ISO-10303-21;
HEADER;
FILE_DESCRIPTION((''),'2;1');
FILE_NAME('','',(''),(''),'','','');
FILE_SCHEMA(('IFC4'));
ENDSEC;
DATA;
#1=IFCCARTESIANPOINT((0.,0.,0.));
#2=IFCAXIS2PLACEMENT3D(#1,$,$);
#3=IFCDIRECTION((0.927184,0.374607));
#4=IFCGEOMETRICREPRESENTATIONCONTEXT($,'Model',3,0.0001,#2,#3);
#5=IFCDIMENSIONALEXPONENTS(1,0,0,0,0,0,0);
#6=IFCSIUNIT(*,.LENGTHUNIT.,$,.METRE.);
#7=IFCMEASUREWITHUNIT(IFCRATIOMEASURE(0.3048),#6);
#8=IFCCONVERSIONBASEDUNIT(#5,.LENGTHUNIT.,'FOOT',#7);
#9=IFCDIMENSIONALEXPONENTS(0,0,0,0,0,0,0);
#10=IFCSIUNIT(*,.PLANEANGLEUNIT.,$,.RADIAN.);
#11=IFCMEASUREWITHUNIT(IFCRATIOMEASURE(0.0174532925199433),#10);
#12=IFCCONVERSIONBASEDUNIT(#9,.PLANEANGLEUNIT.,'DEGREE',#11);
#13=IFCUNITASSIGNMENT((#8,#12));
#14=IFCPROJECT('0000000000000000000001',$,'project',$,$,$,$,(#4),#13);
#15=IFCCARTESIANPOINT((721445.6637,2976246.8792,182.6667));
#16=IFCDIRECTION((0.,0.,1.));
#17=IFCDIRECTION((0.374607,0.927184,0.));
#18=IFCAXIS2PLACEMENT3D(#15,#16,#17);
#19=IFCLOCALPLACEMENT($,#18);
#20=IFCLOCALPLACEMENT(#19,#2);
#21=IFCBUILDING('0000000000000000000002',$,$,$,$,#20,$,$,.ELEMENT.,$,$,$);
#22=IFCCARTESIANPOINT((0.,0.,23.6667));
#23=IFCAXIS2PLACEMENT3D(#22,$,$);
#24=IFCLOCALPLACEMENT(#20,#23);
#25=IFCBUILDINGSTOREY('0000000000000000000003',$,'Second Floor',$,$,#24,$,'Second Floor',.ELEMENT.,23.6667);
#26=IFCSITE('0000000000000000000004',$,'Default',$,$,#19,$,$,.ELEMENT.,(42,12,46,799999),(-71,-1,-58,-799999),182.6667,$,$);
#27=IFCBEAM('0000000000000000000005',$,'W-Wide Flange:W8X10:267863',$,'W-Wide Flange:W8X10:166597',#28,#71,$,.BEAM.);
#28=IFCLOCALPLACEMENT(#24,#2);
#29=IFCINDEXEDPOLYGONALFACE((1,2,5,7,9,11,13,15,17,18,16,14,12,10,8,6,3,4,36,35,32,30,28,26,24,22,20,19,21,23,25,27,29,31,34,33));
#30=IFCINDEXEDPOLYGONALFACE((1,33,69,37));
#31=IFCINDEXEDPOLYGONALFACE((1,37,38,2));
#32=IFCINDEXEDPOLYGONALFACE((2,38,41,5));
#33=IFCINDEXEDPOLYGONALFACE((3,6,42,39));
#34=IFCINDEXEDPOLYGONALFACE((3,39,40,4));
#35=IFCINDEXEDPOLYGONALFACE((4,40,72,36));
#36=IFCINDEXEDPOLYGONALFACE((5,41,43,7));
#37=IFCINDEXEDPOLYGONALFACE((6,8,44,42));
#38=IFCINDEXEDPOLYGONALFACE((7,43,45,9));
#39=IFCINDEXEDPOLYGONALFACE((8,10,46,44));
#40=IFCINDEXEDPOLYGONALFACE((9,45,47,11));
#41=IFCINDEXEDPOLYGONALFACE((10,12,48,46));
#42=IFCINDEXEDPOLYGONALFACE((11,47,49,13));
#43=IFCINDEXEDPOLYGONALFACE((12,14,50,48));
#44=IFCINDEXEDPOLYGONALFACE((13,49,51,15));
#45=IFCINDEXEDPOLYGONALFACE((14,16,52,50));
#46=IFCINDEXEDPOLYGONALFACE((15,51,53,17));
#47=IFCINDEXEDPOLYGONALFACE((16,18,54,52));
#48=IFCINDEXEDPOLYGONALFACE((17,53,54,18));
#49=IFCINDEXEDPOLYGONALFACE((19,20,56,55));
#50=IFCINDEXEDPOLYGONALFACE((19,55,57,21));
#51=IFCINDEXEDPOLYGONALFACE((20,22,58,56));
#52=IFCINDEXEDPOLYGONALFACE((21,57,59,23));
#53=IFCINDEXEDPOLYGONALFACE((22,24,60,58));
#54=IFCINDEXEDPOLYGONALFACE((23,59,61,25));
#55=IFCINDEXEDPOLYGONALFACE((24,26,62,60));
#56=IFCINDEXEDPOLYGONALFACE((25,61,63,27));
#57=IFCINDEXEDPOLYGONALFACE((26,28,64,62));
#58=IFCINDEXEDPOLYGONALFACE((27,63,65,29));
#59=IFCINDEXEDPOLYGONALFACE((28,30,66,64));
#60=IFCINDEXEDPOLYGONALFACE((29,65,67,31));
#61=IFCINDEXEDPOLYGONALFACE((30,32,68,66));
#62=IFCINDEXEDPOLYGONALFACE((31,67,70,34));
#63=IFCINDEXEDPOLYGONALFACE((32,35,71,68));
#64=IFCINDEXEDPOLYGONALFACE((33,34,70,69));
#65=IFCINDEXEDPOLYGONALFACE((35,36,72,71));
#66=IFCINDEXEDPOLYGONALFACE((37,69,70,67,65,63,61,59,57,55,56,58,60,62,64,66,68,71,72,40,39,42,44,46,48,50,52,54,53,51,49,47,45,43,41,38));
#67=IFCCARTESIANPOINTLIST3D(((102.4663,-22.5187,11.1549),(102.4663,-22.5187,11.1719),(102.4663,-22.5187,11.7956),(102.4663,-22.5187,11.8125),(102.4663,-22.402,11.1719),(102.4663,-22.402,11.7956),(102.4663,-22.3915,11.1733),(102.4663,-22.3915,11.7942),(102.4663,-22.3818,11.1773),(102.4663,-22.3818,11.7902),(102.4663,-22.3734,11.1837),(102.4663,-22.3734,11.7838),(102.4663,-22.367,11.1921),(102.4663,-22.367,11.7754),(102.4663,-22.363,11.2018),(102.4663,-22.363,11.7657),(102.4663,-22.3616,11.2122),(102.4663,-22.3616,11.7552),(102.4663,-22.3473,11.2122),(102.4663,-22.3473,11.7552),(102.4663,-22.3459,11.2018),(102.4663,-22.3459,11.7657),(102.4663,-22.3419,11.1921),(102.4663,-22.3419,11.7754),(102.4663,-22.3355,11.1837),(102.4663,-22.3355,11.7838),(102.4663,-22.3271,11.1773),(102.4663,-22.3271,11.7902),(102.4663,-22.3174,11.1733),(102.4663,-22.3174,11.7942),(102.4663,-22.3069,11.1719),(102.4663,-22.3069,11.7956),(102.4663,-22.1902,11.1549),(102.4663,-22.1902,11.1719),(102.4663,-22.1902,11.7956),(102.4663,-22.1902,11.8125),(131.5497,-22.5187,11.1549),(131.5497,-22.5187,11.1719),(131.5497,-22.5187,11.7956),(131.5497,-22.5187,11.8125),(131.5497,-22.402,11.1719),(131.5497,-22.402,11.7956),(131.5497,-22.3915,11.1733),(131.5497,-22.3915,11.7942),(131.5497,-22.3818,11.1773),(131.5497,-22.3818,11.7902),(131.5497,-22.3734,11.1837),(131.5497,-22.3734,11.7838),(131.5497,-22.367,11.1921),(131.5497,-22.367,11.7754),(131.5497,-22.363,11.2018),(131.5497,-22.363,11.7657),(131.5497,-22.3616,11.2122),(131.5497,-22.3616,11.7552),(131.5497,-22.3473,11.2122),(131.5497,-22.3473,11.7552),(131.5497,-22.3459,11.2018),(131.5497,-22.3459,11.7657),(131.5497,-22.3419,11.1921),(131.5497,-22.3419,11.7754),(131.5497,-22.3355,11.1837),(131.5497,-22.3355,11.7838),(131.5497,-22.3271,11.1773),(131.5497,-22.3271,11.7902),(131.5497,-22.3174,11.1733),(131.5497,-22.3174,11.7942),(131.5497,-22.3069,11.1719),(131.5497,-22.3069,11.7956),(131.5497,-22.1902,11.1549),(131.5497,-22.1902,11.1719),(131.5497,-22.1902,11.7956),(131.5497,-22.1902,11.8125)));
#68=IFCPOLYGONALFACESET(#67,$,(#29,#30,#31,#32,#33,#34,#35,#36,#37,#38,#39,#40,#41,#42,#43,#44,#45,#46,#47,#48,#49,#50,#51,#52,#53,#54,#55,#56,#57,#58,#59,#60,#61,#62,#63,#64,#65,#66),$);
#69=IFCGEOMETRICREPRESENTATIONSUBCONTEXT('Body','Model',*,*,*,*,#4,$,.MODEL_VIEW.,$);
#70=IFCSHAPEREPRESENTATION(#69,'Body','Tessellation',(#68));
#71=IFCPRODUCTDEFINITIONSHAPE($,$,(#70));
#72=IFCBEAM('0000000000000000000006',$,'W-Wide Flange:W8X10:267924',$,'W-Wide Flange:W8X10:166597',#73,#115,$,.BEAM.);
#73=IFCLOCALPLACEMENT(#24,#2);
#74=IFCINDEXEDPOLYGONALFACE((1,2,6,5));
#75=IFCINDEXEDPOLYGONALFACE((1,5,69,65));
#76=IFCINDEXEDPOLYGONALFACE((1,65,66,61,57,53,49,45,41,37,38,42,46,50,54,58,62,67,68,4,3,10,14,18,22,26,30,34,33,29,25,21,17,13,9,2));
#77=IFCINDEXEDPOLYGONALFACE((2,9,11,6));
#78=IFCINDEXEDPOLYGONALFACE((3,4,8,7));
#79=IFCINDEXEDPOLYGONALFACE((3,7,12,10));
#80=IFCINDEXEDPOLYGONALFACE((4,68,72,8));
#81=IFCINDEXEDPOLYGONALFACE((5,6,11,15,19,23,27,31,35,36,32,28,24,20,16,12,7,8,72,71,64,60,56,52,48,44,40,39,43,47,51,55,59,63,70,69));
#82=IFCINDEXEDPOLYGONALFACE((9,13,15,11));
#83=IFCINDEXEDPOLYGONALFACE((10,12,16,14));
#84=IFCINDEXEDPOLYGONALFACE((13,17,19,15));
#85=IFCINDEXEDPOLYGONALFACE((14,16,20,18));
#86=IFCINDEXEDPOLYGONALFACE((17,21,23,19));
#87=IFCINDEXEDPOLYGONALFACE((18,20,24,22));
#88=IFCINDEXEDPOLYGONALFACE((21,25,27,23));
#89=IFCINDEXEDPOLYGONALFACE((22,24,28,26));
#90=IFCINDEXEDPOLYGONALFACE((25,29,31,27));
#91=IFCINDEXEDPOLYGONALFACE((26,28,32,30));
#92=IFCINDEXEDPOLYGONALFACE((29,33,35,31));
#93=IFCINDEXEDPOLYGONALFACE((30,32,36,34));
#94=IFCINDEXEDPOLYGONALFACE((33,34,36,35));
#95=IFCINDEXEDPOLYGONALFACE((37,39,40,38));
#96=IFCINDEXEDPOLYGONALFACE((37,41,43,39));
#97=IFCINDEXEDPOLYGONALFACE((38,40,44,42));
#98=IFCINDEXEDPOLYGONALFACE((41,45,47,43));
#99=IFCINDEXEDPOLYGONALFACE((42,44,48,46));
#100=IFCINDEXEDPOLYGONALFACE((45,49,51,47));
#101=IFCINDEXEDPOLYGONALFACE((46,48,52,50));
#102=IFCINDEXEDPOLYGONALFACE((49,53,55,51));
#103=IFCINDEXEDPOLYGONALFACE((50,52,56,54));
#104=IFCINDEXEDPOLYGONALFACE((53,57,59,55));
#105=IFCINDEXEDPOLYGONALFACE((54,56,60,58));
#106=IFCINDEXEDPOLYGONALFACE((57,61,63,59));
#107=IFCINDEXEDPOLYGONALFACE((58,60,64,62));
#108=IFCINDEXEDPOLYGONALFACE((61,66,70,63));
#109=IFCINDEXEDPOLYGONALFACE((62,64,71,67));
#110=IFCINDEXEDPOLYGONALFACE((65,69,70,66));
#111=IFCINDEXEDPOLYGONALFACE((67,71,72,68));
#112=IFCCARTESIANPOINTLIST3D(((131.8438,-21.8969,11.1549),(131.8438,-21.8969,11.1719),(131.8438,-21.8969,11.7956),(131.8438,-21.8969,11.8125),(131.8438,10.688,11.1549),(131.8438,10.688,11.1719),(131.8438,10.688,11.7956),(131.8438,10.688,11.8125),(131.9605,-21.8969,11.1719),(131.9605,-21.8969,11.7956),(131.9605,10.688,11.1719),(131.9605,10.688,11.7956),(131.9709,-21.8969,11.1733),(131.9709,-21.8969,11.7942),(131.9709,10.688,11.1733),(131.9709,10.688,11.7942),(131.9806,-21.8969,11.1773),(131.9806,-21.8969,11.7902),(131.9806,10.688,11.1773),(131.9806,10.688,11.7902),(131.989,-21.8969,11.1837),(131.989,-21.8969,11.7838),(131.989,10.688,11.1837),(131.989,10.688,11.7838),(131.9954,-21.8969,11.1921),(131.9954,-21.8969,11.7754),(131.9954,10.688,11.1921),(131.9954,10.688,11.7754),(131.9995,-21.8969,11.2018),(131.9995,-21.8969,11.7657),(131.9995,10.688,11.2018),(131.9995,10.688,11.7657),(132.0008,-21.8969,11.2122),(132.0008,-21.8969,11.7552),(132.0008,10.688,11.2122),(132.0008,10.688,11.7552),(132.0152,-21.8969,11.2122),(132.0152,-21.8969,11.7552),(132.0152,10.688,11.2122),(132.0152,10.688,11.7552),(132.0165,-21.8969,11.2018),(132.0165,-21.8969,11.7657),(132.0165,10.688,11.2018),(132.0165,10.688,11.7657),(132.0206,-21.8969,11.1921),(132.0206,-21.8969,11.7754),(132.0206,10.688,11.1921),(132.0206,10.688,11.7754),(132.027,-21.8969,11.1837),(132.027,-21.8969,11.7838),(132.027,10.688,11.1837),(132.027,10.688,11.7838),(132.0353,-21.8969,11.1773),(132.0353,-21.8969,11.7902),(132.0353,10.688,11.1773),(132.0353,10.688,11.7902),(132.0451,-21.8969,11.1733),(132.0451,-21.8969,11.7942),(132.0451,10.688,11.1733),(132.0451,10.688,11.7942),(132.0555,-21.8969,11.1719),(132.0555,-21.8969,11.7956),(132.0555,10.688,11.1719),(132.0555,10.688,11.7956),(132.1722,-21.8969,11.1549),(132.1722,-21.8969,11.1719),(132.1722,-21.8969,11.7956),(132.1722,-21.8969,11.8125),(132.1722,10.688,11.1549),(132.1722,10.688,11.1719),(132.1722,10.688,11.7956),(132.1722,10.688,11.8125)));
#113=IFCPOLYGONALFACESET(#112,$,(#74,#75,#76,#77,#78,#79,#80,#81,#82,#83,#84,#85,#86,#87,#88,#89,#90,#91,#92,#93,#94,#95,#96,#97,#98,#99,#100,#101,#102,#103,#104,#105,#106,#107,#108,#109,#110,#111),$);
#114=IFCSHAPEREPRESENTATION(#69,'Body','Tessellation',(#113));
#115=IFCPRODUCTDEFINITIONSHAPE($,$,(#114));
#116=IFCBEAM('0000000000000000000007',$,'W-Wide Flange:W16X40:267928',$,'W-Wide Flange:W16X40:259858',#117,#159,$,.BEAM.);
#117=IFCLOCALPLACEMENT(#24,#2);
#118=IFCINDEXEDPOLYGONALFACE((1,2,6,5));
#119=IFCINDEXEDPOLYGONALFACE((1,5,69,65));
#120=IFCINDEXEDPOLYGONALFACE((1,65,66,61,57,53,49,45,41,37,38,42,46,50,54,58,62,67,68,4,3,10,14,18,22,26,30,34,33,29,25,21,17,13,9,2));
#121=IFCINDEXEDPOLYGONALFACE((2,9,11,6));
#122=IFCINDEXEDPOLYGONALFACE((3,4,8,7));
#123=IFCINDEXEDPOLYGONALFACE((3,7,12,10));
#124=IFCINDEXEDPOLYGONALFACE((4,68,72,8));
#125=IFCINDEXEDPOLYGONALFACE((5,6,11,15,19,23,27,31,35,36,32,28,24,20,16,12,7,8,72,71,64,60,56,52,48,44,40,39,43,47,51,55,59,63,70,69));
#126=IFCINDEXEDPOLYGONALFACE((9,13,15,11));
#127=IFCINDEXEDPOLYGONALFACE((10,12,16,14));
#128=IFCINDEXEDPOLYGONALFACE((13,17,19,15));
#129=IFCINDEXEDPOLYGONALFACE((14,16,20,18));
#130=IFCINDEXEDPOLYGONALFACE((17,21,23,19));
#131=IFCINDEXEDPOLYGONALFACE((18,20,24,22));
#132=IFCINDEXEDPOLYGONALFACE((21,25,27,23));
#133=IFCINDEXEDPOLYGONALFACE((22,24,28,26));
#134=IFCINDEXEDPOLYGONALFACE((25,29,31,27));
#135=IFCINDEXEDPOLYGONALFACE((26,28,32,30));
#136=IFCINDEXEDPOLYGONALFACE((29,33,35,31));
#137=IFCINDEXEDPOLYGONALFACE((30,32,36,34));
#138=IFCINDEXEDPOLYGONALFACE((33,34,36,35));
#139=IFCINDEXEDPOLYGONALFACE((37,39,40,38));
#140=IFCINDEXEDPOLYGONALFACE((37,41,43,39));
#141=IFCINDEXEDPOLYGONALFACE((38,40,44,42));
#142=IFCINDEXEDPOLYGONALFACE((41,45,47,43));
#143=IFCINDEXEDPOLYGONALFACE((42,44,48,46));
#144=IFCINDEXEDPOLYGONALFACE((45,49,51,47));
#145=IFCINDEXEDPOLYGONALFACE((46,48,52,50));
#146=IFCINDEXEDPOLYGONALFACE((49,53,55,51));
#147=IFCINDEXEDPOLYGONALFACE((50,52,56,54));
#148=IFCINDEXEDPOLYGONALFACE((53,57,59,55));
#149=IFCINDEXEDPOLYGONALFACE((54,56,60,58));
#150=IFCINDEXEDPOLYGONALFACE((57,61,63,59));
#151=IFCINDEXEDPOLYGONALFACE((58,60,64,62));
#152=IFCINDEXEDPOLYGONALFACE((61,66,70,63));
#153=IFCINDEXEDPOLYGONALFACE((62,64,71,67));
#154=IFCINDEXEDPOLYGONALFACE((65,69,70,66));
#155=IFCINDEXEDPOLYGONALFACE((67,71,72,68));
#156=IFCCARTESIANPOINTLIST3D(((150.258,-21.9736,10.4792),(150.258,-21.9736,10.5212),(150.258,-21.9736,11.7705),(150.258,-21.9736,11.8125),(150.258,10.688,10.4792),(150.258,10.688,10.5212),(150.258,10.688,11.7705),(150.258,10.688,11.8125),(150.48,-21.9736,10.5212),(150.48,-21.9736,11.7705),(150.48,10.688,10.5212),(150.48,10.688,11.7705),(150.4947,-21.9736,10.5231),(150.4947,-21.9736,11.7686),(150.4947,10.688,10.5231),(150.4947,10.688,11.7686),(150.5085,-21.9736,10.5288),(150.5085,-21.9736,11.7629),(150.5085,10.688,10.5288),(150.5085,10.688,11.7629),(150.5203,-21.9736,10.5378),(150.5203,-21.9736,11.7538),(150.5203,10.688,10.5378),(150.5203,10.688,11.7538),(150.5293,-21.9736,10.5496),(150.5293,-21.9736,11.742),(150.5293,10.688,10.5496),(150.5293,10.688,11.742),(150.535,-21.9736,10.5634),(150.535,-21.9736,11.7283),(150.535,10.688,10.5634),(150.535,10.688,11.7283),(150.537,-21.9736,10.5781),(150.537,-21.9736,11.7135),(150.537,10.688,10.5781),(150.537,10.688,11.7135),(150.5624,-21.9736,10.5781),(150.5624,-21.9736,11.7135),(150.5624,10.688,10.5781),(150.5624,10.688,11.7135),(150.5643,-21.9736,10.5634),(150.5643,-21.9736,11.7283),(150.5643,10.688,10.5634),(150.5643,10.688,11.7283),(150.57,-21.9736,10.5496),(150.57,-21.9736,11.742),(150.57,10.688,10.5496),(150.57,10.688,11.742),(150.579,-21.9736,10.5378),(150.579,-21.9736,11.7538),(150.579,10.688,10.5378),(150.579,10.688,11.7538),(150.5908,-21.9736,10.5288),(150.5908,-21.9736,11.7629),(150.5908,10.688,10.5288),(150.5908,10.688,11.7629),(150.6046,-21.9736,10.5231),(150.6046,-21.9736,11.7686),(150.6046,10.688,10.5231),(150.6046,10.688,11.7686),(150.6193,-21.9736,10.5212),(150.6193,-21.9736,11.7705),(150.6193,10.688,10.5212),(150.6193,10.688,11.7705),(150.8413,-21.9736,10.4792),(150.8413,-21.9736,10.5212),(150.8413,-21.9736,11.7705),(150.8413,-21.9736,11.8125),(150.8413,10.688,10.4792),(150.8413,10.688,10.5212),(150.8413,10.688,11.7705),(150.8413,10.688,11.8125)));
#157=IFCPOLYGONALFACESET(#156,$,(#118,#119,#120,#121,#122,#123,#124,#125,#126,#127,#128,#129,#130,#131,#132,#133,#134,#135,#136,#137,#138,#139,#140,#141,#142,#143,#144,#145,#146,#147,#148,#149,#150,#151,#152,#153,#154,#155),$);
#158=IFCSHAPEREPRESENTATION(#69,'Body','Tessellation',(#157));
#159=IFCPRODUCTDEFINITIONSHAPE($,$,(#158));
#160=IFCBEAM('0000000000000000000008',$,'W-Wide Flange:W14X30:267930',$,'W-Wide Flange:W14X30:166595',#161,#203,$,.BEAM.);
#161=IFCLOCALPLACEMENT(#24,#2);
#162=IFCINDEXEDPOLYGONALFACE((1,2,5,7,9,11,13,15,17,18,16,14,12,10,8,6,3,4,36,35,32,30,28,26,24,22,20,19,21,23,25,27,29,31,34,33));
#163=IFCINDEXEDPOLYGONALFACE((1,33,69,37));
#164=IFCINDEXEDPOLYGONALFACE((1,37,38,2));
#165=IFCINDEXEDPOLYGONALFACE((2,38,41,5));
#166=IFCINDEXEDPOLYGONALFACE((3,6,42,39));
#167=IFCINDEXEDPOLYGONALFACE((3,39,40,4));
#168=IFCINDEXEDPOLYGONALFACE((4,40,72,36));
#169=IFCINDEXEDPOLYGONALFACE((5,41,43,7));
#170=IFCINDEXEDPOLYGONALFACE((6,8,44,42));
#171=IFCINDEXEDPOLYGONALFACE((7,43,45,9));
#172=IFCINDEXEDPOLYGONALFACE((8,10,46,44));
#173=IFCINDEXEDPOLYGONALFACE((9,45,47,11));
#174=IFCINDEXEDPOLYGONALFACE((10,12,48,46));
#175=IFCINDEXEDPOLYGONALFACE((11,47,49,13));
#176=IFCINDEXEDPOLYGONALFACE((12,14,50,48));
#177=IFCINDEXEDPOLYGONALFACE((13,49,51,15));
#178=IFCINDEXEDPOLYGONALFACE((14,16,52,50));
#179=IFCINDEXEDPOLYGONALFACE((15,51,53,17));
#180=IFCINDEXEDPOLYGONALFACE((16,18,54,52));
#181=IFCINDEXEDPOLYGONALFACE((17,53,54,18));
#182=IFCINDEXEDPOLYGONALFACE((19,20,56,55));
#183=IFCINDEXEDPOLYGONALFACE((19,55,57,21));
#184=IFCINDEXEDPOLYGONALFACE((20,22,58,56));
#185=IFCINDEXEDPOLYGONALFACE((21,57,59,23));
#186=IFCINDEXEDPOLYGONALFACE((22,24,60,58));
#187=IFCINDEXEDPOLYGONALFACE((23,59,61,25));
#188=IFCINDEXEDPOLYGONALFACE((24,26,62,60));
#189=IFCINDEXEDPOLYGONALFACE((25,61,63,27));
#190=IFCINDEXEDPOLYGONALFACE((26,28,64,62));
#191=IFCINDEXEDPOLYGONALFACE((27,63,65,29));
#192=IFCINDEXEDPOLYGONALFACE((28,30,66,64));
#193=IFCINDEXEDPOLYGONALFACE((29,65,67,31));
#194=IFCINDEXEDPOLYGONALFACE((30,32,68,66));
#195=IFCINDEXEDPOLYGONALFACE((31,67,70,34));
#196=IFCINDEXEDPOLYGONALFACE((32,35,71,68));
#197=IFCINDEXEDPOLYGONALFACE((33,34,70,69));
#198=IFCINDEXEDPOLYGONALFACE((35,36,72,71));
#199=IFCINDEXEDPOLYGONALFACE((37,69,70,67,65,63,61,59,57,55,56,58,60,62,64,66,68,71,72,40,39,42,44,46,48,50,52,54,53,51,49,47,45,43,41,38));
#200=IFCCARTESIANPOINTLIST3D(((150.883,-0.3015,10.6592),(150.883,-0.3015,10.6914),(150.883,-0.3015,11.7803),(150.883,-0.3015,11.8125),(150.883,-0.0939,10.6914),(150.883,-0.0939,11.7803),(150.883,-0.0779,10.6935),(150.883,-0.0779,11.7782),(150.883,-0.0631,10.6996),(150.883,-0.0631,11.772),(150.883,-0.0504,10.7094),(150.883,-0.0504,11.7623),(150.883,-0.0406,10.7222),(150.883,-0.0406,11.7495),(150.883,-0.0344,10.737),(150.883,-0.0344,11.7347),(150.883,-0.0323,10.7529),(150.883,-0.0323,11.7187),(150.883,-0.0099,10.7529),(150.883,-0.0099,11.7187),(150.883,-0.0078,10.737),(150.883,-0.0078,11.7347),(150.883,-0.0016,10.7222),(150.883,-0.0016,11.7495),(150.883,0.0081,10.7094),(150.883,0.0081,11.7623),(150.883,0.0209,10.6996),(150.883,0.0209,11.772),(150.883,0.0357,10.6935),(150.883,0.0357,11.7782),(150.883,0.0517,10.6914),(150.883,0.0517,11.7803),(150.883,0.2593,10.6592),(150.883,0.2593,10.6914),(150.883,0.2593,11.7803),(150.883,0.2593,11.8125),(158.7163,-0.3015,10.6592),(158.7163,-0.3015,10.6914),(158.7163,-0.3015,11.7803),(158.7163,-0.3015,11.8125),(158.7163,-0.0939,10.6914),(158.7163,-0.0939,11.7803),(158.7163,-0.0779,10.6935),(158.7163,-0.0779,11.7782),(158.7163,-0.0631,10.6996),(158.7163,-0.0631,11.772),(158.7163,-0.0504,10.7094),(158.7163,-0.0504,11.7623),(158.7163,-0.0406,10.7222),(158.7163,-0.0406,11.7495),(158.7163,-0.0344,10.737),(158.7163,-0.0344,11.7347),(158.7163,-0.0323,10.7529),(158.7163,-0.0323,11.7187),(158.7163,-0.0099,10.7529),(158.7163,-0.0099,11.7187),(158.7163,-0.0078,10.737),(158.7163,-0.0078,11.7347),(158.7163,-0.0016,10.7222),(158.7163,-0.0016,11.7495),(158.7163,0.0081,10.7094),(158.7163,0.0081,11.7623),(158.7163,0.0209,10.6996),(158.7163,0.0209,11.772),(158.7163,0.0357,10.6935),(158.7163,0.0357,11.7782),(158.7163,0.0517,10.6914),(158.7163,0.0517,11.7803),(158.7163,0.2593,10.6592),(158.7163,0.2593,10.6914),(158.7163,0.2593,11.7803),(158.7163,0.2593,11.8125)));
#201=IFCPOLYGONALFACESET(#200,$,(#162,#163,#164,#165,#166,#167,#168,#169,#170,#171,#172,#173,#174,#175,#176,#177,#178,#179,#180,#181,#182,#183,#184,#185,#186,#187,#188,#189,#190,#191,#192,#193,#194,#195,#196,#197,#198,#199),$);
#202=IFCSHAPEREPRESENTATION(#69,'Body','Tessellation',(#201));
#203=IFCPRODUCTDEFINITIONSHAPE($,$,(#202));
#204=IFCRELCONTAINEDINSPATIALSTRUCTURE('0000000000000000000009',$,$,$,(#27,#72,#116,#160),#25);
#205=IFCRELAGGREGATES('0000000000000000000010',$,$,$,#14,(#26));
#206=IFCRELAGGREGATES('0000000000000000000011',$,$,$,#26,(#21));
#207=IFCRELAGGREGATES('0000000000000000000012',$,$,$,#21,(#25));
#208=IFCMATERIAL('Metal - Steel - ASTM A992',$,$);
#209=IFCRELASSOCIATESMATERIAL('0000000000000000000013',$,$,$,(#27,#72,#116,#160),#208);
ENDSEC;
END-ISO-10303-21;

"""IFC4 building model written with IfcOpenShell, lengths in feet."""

from ifc_helpers import new_model, entity, si_unit, converted_unit, direction, frame, frame_2d, origin, place, context, subcontext, project, spatial, i_section, extrude, material, element, save


model = new_model("IFC4")

# Units and contexts
model_context = context("Model", 3, precision=0.0001, world=origin(), true_north=direction((0.927184, 0.374607)))
body_context = subcontext(model_context, "Body", "Model", "MODEL_VIEW")
ifc_project = project(units=[converted_unit("LENGTHUNIT", "FOOT", entity("IfcRatioMeasure", 0.3048), si_unit("LENGTHUNIT", "METRE"), dimensions=[1, 0, 0, 0, 0, 0, 0]), converted_unit("PLANEANGLEUNIT", "DEGREE", entity("IfcRatioMeasure", 0.0174532925199433), si_unit("PLANEANGLEUNIT", "RADIAN"), dimensions=[0, 0, 0, 0, 0, 0, 0])], contexts=[model_context])

# Site, building, storey
site_placement = place(None, frame((721445.6637, 2976246.8792, 182.6667), z_axis=(0.0, 0.0, 1.0), x_axis=(0.374607, 0.927184, 0.0)))
site = spatial("IfcSite", under=ifc_project, at=site_placement, Name="Default", CompositionType="ELEMENT", RefLatitude=(42, 12, 46, 799999), RefLongitude=(-71, -1, -58, -799999), RefElevation=182.6667)
building_placement = place(site_placement, origin())
building = spatial("IfcBuilding", under=site, at=building_placement, CompositionType="ELEMENT")
storey_placement = place(building_placement, frame((0.0, 0.0, 23.6667)))
storey = spatial("IfcBuildingStorey", under=building, at=storey_placement, Name="Second Floor", LongName="Second Floor", CompositionType="ELEMENT", Elevation=23.6667)

# Shared definitions
ifc_material_1 = material(Name="Metal - Steel - ASTM A992")

# Beams
beam_1_placement = place(storey_placement, frame((102.008, -22.3544, 11.8125)))
element("IfcBeam", 1, at=beam_1_placement, inside=storey, material=ifc_material_1, Name="W-Wide Flange:W8X10:267863", ObjectType="W-Wide Flange:W8X10:166597", PredefinedType="BEAM", context=body_context, shape_type="SweptSolid", body=[
    extrude(i_section(OverallWidth=0.3285, OverallDepth=0.6576, WebThickness=0.0143, FlangeThickness=0.0169, FilletRadius=0.0404, at=frame_2d((0.0, 0.0), x_axis=(0.0, 1.0))), frame((0.4583, 0.0, -0.3288), z_axis=(1.0, 0.0, 0.0), x_axis=(0.0, 0.0, -1.0)), (0.0, 0.0, 1.0), 29.0833),
])
beam_2_placement = place(storey_placement, frame((132.008, 11.1456, 11.8125), z_axis=(0.0, 0.0, 1.0), x_axis=(0.0, -1.0, 0.0)))
element("IfcBeam", 2, at=beam_2_placement, inside=storey, material=ifc_material_1, Name="W-Wide Flange:W8X10:267924", ObjectType="W-Wide Flange:W8X10:166597", PredefinedType="BEAM", context=body_context, shape_type="SweptSolid", body=[
    extrude(i_section(OverallWidth=0.3285, OverallDepth=0.6576, WebThickness=0.0143, FlangeThickness=0.0169, FilletRadius=0.0404, at=frame_2d((0.0, 0.0), x_axis=(0.0, 1.0))), frame((0.4575, 0.0, -0.3288), z_axis=(1.0, 0.0, 0.0), x_axis=(0.0, 0.0, -1.0)), (0.0, 0.0, 1.0), 32.585),
])
beam_3_placement = place(storey_placement, frame((150.5497, 11.1456, 11.8125), z_axis=(0.0, 0.0, 1.0), x_axis=(0.0, -1.0, 0.0)))
element("IfcBeam", 3, at=beam_3_placement, inside=storey, material=ifc_material_1, Name="W-Wide Flange:W16X40:267928", ObjectType="W-Wide Flange:W16X40:259858", PredefinedType="BEAM", context=body_context, shape_type="SweptSolid", body=[
    extrude(i_section(OverallWidth=0.5833, OverallDepth=1.3333, WebThickness=0.0254, FlangeThickness=0.042, FilletRadius=0.057, at=frame_2d((0.0, 0.0), x_axis=(0.0, 1.0))), frame((0.4575, 0.0, -0.6667), z_axis=(1.0, 0.0, 0.0), x_axis=(0.0, 0.0, -1.0)), (0.0, 0.0, 1.0), 32.6616),
])
beam_4_placement = place(storey_placement, frame((150.5497, -0.0211, 11.8125)))
element("IfcBeam", 4, at=beam_4_placement, inside=storey, material=ifc_material_1, Name="W-Wide Flange:W14X30:267930", ObjectType="W-Wide Flange:W14X30:166595", PredefinedType="BEAM", context=body_context, shape_type="SweptSolid", body=[
    extrude(i_section(OverallWidth=0.5609, OverallDepth=1.1533, WebThickness=0.0225, FlangeThickness=0.0322, FilletRadius=0.0615, at=frame_2d((0.0, 0.0), x_axis=(0.0, 1.0))), frame((0.3333, 0.0, -0.5767), z_axis=(1.0, 0.0, 0.0), x_axis=(0.0, 0.0, -1.0)), (0.0, 0.0, 1.0), 7.8333),
])

save(model, "model.ifc")
